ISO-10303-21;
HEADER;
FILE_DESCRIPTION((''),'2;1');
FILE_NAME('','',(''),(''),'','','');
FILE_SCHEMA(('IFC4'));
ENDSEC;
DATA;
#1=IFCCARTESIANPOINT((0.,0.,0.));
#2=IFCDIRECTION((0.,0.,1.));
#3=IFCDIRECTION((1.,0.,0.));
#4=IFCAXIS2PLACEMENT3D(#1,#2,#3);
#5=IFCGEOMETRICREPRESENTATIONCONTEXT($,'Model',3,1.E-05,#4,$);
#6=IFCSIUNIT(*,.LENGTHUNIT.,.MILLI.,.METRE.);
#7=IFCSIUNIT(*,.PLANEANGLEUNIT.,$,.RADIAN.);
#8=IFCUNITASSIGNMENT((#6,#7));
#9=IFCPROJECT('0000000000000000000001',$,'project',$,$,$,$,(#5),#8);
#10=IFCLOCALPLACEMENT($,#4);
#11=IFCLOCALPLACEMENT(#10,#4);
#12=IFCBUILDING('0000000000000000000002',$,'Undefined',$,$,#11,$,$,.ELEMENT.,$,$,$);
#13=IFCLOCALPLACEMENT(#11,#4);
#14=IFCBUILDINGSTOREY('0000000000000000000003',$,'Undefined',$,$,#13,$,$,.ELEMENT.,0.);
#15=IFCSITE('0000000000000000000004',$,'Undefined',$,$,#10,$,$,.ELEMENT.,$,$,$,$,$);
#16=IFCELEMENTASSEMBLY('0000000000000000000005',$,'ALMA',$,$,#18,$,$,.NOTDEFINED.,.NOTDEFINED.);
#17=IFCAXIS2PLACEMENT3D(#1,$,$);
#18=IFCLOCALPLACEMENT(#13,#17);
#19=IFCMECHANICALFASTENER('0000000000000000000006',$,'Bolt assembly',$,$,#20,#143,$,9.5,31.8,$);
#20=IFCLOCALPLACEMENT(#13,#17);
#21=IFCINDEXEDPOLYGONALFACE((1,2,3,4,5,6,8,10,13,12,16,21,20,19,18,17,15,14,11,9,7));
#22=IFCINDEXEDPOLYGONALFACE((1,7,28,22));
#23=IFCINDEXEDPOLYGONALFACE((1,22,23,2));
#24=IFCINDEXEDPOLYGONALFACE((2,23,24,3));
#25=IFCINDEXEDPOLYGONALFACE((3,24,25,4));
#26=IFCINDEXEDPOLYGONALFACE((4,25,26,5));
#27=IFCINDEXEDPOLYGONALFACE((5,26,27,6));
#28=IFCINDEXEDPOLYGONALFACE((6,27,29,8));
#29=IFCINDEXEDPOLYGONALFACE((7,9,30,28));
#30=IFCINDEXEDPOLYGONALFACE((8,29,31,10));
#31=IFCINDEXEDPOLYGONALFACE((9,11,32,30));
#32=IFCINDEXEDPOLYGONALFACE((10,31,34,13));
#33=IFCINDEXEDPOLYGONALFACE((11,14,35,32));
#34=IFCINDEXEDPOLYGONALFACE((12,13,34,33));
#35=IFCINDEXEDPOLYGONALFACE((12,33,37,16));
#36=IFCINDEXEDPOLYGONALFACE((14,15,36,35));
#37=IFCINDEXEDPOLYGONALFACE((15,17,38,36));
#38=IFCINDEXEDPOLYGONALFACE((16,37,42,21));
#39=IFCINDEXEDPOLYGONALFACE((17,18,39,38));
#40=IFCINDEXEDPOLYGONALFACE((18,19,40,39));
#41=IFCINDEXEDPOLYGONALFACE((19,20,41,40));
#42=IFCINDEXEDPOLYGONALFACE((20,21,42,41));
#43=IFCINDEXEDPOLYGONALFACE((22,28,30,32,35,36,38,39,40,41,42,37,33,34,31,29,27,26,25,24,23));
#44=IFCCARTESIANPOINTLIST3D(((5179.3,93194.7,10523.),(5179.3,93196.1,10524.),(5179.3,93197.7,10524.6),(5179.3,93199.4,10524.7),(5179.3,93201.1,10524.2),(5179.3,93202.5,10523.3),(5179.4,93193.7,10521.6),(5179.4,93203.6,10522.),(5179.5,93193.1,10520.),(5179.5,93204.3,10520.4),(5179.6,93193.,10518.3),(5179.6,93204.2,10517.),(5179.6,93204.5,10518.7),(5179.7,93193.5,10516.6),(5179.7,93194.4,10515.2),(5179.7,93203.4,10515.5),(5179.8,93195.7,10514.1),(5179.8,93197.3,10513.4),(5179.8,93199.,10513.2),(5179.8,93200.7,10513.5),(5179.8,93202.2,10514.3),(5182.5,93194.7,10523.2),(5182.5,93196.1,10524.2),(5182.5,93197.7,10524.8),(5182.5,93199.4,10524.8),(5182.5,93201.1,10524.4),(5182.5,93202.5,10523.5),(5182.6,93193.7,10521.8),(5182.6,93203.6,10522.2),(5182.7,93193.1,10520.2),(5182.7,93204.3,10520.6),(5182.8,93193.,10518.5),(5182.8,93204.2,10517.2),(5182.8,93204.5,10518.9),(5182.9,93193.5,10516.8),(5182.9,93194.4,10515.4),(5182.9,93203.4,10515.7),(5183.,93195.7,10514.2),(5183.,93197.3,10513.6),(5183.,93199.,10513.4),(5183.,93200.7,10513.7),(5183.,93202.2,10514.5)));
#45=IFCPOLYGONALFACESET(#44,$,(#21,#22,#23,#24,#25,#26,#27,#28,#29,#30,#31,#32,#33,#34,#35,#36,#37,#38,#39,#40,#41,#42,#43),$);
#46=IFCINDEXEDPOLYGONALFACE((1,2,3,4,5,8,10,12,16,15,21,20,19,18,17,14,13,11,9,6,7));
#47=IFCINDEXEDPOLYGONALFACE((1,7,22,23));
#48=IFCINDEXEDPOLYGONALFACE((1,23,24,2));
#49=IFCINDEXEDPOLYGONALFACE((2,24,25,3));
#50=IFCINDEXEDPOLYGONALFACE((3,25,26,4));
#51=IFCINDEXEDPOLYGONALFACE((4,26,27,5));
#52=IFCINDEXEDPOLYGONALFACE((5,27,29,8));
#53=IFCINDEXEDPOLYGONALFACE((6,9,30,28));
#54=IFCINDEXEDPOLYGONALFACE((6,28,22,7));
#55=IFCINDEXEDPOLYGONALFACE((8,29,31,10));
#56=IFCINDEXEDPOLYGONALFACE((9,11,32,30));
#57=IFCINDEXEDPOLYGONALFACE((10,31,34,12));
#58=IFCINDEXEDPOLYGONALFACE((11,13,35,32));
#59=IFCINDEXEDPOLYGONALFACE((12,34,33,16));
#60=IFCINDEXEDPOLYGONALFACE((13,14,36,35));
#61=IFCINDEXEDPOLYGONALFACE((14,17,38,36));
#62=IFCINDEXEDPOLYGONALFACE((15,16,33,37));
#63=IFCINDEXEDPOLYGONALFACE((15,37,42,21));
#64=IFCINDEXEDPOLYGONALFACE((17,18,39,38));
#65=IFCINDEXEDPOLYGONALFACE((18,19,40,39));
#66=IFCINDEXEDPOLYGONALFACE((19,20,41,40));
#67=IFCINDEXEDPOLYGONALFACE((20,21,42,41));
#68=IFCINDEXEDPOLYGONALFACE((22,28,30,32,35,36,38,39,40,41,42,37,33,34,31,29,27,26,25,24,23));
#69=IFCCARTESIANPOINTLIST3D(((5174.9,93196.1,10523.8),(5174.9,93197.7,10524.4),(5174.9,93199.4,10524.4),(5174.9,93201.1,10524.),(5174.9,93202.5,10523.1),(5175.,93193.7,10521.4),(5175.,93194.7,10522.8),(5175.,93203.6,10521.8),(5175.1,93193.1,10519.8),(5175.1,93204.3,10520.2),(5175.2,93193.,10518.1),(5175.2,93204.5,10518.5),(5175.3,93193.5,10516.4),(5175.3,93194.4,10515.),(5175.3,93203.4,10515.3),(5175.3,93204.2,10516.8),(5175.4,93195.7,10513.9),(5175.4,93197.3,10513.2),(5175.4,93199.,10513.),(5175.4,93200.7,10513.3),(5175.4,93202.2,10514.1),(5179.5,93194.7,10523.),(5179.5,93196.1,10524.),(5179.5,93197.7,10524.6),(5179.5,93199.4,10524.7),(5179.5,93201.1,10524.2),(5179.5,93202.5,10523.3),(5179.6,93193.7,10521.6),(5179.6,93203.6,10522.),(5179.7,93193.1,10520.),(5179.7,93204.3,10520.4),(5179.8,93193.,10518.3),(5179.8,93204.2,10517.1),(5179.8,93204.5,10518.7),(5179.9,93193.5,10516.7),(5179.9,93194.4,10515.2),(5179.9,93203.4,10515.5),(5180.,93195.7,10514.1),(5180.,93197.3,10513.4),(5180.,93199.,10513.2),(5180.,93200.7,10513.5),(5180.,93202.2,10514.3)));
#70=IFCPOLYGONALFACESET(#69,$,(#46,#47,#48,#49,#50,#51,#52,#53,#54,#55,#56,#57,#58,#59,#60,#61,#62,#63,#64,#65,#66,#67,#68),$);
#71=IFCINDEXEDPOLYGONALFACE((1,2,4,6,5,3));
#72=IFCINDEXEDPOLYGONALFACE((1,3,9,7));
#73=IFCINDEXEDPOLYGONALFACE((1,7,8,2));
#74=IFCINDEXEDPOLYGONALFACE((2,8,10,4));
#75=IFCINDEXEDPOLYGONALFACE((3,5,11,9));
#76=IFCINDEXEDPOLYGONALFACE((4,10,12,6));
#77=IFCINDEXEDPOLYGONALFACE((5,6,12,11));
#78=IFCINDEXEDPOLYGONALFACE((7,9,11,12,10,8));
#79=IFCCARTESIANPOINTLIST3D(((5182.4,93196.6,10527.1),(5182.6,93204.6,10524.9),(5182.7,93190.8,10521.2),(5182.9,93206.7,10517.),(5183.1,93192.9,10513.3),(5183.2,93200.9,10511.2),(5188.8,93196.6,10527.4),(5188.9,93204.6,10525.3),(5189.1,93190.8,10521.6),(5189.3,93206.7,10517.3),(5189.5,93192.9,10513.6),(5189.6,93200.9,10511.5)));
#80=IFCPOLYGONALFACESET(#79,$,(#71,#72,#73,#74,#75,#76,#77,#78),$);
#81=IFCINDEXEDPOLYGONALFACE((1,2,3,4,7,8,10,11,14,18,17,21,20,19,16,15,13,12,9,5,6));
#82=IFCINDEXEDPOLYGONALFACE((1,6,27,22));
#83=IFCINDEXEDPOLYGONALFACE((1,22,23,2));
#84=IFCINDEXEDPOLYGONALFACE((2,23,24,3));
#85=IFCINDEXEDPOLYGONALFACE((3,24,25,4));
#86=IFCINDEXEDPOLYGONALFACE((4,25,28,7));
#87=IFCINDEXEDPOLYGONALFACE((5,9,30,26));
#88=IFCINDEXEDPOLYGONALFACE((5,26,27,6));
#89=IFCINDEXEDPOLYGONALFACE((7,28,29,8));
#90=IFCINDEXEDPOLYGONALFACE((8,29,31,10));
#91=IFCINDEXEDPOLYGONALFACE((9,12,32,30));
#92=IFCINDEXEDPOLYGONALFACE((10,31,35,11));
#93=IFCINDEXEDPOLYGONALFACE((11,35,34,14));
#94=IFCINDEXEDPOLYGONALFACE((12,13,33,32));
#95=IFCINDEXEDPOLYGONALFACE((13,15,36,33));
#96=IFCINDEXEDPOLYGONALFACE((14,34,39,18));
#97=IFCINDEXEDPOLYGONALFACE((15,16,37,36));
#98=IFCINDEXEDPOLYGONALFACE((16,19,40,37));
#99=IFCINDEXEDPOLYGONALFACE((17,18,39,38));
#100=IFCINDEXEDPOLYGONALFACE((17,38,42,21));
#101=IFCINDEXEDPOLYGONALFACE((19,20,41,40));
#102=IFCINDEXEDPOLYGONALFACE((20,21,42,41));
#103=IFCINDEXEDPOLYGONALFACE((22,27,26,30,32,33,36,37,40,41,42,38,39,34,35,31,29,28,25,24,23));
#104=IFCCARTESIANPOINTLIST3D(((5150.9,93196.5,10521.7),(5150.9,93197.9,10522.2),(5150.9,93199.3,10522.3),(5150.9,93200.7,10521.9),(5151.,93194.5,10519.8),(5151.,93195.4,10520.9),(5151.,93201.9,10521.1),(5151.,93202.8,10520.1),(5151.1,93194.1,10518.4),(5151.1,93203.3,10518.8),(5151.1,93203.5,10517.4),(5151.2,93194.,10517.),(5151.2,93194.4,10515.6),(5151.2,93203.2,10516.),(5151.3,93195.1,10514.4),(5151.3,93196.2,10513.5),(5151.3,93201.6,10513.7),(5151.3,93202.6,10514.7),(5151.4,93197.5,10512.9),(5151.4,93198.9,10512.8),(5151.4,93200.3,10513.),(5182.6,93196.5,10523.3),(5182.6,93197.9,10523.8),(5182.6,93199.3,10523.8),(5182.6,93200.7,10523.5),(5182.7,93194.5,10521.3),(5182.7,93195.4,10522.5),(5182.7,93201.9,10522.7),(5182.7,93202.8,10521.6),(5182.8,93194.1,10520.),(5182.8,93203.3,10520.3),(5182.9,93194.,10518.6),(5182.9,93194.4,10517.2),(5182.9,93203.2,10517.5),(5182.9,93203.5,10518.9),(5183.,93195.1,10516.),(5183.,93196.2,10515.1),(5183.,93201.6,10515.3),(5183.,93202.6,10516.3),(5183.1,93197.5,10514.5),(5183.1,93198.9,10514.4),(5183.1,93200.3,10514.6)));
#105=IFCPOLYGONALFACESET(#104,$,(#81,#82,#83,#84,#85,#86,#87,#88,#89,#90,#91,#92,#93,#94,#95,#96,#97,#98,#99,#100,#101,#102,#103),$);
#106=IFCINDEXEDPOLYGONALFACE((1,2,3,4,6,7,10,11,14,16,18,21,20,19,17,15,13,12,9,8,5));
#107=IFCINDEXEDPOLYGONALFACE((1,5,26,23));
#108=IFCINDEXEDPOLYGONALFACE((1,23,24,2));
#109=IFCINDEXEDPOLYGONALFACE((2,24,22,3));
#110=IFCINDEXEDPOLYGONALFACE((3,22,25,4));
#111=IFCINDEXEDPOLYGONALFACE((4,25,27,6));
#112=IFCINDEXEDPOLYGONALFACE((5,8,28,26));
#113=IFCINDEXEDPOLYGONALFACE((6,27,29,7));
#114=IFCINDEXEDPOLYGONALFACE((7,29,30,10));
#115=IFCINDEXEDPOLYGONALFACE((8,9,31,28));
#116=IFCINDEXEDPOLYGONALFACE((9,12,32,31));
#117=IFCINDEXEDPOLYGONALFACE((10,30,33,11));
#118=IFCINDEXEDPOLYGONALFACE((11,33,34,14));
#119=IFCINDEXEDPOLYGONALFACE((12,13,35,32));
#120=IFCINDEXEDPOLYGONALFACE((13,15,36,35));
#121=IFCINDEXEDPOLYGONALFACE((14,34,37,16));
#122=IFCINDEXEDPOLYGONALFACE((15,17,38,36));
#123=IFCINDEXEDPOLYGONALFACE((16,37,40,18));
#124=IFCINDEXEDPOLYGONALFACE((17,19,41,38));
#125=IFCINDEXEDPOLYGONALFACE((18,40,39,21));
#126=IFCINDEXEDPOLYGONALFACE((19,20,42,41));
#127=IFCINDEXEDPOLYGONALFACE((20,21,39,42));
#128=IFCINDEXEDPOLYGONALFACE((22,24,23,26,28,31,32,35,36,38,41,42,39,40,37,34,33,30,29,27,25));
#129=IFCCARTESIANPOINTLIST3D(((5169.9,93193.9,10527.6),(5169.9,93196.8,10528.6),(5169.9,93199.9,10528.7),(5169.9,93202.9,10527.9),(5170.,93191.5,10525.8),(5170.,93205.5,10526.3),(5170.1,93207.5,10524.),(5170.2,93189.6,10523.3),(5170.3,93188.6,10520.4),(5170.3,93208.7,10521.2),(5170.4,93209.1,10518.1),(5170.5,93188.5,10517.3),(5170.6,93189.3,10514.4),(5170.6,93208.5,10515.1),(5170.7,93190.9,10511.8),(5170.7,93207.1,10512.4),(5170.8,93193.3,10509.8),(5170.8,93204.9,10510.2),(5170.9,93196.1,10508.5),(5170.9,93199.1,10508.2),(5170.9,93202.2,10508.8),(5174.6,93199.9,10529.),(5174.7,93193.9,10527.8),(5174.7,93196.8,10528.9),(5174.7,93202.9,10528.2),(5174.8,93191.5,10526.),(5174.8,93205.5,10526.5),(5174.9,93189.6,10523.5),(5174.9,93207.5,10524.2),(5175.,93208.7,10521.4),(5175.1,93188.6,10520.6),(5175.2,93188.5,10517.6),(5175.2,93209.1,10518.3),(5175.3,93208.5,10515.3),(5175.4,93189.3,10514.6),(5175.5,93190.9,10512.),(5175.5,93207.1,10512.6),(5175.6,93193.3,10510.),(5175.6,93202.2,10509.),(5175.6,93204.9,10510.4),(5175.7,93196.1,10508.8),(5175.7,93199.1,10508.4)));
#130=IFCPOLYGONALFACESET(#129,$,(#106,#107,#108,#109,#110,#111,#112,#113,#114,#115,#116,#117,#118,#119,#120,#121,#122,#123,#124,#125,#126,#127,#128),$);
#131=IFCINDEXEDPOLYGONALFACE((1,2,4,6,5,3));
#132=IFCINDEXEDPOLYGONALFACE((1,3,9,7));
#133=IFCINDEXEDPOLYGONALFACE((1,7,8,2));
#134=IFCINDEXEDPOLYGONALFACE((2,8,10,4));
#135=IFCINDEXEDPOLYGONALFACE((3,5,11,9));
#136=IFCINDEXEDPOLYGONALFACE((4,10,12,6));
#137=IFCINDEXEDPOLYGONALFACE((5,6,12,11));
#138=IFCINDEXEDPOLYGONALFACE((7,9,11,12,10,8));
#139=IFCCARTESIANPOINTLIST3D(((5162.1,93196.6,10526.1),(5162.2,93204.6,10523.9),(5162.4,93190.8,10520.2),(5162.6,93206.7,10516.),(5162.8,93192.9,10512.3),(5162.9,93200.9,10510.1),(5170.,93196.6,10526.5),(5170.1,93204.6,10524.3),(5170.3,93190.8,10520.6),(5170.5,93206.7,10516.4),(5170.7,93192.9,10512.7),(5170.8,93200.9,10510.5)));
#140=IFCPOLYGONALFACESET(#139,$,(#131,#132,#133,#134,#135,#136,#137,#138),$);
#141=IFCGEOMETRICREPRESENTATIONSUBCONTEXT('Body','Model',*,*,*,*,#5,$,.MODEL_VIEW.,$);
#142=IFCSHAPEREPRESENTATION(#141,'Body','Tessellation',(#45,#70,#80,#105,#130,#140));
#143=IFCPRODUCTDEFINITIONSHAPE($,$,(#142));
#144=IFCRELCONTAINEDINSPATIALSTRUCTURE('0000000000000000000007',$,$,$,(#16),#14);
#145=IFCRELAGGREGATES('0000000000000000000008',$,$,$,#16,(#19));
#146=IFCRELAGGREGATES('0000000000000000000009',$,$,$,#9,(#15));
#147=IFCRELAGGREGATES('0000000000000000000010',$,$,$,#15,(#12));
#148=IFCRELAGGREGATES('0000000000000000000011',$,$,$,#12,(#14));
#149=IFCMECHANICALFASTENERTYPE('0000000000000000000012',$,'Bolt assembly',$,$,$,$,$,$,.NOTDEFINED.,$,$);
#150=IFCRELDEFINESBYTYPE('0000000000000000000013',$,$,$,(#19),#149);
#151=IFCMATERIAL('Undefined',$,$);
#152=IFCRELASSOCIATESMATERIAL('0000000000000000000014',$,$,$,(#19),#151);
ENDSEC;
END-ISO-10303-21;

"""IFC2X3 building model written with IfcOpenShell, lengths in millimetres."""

from ifc_helpers import new_model, si_unit, frame, origin_with_axes, origin_2d_with_axis, place, context, subcontext, project, spatial, polyline, circle, outline, extrude, source, transform, mapped, material, type_object, element, aggregate, save


model = new_model("IFC2X3")

# Units and contexts
model_context = context("Model", 3, precision=1e-05, world=origin_with_axes())
body_context = subcontext(model_context, "Body", "Model", "MODEL_VIEW")
ifc_project = project(units=[si_unit("LENGTHUNIT", "METRE", prefix="MILLI"), si_unit("PLANEANGLEUNIT", "RADIAN")], contexts=[model_context])

# Site, building, storey
site_placement = place(None, origin_with_axes())
site = spatial("IfcSite", under=ifc_project, at=site_placement, Name="Undefined", CompositionType="ELEMENT")
building_placement = place(site_placement, origin_with_axes())
building = spatial("IfcBuilding", under=site, at=building_placement, Name="Undefined", CompositionType="ELEMENT")
storey_placement = place(building_placement, origin_with_axes())
storey = spatial("IfcBuildingStorey", under=building, at=storey_placement, Name="Undefined", CompositionType="ELEMENT", Elevation=0.0)

# Element assembly
assembly_1_placement = place(storey_placement, origin_with_axes())
assembly_1 = element("IfcElementAssembly", 1, at=assembly_1_placement, inside=storey, Name="ALMA", AssemblyPlace="NOTDEFINED", PredefinedType="NOTDEFINED")

# Shared definitions
ifc_material_1 = material(Name="Undefined")
mechanical_fastener_type = type_object("IfcMechanicalFastenerType", Name="Bolt assembly")

# Mechanical fastener
shared_shape_1 = source(origin_with_axes(), body_context, "Body", "SweptSolid", [
    extrude(circle(Radius=5.8, at=origin_2d_with_axis()), frame((0.0, -7.6, 0.0), z_axis=(0.0, 1.0, 0.0), x_axis=(1.0, 0.0, 0.0)), (0.0, 0.0, 1.0), 3.2),
    extrude(circle(Radius=5.8, at=origin_2d_with_axis()), frame((0.0, -4.6, 0.0), z_axis=(0.0, 1.0, 0.0), x_axis=(1.0, 0.0, 0.0)), (0.0, 0.0, 1.0), 4.6),
    extrude(outline(polyline([(7.1, -4.1), (7.1, 4.1), (0.0, 8.2), (-7.1, 4.1), (-7.1, -4.1), (0.0, -8.2), (7.1, -4.1)])), frame((0.0, -14.0, 0.0), z_axis=(0.0, 1.0, 0.0), x_axis=(1.0, 0.0, 0.0)), (0.0, 0.0, 1.0), 6.3),
    extrude(circle(Radius=4.8, at=origin_2d_with_axis()), frame((0.0, -7.7, 0.0), z_axis=(0.0, 1.0, 0.0), x_axis=(1.0, 0.0, 0.0)), (0.0, 0.0, 1.0), 31.8),
    extrude(circle(Radius=10.3, at=origin_2d_with_axis()), frame((0.0, 0.0, 0.0), z_axis=(0.0, 1.0, 0.0), x_axis=(1.0, 0.0, 0.0)), (0.0, 0.0, 1.0), 4.8),
    extrude(outline(polyline([(7.1, -4.1), (7.1, 4.1), (0.0, 8.2), (-7.1, 4.1), (-7.1, -4.1), (0.0, -8.2), (7.1, -4.1)])), frame((0.0, 4.8, 0.0), z_axis=(0.0, 1.0, 0.0), x_axis=(1.0, 0.0, 0.0)), (0.0, 0.0, 1.0), 7.9),
])
mechanical_fastener_1_placement = place(assembly_1_placement, frame((5175.2, 93198.8, 10518.7), z_axis=(0.035282, -0.707107, -0.706226), x_axis=(-0.035282, -0.707107, 0.706226)))
mechanical_fastener_1 = element("IfcMechanicalFastener", 2, at=mechanical_fastener_1_placement, type_object=mechanical_fastener_type, material=ifc_material_1, Name="Bolt assembly", NominalDiameter=9.5, NominalLength=31.8, context=body_context, shape_type="MappedRepresentation", body=[
    mapped(shared_shape_1, transform((0.0, 0.0, 0.0))),
])
aggregate(assembly_1, [mechanical_fastener_1])

save(model, "model.ifc")
